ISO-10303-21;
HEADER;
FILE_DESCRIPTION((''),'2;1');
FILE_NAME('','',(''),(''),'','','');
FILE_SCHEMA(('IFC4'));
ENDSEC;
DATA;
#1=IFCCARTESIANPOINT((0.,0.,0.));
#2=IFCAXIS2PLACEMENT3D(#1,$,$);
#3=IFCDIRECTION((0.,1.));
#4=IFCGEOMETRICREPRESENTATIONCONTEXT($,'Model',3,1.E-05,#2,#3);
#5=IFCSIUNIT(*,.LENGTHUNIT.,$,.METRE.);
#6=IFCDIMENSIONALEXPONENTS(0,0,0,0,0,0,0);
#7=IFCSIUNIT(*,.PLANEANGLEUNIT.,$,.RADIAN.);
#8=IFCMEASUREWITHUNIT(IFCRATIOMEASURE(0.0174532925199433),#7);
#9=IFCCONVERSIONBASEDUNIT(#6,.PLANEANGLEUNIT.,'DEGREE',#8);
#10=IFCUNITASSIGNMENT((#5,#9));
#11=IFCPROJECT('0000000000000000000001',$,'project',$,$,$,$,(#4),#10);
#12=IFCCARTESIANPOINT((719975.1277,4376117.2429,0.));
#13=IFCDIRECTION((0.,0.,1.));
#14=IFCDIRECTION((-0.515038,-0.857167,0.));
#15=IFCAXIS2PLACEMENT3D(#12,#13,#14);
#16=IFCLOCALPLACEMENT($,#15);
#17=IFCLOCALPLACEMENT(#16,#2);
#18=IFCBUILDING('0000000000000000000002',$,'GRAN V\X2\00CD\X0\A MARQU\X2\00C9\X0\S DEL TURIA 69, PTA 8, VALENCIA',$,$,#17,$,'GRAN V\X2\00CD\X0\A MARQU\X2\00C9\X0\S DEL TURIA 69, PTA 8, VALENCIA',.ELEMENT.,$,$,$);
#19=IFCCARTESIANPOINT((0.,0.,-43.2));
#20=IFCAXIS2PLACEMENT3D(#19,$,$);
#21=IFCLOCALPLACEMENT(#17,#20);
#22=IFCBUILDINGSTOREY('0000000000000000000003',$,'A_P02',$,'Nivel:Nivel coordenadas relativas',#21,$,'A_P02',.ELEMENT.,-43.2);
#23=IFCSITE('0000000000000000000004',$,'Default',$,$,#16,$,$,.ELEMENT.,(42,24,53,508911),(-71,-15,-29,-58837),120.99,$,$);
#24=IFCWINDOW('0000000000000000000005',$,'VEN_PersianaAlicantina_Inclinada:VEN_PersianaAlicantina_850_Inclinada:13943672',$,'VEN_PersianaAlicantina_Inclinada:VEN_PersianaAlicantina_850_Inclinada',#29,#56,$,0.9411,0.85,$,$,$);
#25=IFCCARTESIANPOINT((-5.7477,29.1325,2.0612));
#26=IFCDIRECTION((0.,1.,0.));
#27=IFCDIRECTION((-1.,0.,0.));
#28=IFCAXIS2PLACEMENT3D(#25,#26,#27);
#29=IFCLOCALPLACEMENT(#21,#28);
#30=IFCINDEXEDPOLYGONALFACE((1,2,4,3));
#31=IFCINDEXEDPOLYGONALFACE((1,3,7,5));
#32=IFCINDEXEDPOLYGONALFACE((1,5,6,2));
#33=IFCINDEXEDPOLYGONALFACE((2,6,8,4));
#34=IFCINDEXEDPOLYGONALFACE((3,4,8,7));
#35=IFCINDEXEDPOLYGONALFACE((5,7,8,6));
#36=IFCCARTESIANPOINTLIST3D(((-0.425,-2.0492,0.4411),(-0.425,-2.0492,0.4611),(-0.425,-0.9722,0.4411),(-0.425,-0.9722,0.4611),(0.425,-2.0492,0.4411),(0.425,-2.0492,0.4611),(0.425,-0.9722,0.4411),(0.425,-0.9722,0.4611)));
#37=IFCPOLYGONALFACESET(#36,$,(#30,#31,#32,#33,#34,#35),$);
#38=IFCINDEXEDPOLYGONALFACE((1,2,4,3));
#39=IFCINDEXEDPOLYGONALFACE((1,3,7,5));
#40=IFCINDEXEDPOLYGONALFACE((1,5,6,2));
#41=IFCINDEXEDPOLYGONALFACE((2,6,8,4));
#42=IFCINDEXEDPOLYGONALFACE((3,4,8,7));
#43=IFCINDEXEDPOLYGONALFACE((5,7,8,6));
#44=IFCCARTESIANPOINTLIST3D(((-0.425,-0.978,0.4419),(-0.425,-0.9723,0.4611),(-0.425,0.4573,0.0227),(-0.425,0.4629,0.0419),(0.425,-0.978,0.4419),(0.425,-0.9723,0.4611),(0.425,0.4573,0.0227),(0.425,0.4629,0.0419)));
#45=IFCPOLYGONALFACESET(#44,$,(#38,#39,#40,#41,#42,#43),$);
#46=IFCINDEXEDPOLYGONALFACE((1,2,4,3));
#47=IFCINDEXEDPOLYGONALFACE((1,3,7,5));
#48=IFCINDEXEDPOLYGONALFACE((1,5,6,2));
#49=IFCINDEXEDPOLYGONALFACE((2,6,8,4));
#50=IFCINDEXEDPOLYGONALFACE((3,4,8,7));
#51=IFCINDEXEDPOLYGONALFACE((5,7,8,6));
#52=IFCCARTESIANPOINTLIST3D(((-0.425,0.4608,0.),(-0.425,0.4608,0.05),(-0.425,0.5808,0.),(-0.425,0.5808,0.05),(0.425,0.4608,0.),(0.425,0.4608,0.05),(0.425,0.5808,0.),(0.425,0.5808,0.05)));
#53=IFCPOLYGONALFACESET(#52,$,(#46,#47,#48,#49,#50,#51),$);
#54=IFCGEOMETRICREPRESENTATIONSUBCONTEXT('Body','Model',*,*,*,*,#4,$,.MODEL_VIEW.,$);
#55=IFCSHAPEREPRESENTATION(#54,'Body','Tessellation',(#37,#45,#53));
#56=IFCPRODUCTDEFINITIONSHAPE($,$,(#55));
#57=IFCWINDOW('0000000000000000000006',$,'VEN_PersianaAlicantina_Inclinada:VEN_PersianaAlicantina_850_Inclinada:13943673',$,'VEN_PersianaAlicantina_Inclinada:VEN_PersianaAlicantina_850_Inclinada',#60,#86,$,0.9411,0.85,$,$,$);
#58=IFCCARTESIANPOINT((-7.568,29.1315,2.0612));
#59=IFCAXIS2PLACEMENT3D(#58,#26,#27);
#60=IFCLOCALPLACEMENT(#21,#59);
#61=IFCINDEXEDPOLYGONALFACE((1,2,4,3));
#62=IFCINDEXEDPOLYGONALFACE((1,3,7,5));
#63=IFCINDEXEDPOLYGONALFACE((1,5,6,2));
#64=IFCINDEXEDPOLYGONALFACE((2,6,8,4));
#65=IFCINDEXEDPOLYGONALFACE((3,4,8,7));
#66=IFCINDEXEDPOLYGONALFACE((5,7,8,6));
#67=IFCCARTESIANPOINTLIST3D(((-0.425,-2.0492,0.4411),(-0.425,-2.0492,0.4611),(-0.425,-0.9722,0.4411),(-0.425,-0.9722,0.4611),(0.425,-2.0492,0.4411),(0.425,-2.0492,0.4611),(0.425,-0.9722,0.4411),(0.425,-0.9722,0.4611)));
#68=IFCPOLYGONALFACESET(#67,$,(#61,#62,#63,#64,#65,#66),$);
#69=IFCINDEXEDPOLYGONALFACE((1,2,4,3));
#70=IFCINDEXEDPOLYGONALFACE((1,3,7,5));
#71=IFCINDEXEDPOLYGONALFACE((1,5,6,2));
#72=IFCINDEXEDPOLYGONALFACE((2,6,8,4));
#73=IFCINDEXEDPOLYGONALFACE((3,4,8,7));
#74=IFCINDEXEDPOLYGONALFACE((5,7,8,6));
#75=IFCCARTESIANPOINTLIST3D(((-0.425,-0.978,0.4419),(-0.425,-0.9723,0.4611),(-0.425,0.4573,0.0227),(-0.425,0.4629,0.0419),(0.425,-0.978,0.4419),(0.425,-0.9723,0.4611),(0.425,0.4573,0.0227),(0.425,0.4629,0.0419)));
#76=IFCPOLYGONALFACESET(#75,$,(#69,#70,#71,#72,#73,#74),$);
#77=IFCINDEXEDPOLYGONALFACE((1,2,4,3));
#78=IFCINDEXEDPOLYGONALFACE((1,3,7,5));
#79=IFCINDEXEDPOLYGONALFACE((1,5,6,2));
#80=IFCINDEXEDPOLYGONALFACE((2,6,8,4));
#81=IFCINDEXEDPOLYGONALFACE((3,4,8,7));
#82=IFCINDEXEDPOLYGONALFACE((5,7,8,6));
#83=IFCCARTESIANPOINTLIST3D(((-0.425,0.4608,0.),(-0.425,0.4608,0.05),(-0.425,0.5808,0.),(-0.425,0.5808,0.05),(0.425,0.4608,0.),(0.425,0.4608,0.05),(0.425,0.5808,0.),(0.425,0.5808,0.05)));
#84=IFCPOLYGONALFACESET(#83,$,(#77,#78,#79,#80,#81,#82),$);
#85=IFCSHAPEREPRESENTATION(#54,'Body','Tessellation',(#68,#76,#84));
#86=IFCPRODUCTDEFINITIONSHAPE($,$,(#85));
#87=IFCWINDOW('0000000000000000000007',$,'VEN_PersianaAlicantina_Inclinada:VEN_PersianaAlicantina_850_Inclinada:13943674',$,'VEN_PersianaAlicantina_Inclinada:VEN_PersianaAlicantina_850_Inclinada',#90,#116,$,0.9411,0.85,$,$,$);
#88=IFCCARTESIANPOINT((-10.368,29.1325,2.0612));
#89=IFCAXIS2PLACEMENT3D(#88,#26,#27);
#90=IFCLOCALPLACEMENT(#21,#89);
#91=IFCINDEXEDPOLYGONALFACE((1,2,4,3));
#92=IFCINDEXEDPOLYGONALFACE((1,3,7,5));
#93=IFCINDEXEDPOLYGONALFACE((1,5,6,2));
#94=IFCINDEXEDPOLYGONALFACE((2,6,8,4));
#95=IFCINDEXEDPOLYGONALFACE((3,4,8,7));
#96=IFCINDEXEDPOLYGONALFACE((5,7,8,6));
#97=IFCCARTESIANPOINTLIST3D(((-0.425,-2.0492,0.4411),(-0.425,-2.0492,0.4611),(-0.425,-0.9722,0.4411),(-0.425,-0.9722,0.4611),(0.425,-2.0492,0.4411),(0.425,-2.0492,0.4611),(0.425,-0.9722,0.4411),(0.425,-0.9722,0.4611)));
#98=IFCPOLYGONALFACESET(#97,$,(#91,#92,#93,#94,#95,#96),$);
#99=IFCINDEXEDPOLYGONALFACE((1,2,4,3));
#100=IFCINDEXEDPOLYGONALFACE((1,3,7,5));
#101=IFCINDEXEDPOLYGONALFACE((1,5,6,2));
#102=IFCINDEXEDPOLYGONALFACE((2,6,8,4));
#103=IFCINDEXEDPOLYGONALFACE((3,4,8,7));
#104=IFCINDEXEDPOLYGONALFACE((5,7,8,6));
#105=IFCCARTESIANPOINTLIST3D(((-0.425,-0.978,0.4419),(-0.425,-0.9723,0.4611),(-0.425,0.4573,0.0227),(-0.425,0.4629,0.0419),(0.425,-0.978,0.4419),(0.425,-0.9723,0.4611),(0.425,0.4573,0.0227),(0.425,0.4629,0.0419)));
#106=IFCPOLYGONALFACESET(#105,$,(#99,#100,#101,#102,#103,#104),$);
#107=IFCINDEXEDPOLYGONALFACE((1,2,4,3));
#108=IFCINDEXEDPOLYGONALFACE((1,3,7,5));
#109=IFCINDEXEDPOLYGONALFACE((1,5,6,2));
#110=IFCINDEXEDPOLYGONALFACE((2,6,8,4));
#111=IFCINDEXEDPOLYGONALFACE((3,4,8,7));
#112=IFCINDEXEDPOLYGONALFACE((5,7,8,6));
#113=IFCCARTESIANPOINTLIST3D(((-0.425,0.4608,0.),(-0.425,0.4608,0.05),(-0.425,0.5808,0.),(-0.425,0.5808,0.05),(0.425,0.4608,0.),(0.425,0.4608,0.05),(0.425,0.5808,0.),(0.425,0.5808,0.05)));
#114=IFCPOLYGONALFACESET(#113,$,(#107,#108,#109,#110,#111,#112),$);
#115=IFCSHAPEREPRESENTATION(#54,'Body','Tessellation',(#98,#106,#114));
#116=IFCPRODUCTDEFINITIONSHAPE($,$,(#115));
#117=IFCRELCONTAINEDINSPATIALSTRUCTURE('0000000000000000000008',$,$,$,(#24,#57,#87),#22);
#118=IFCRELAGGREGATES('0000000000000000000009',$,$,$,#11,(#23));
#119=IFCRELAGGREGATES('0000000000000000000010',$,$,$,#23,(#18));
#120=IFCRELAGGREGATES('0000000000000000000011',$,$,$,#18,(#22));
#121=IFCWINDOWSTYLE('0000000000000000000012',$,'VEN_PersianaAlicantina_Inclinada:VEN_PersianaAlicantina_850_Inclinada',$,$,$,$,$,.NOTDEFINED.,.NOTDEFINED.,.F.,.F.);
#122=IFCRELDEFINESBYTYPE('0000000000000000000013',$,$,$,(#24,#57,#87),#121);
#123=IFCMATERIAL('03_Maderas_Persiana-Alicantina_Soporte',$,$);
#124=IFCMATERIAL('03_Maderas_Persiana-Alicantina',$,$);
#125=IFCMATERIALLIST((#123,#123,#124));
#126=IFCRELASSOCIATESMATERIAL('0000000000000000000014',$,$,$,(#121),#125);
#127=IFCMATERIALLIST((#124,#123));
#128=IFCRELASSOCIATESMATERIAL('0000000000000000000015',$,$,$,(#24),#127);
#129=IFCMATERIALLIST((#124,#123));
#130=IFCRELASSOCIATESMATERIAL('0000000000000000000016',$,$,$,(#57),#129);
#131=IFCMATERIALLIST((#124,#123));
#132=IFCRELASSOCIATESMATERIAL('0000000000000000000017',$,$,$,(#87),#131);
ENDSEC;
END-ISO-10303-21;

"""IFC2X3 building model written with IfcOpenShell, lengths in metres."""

from ifc_helpers import new_model, entity, si_unit, converted_unit, direction, frame, frame_2d, origin, place, context, subcontext, project, spatial, rectangle, extrude, source, transform, mapped, material, material_list, type_object, type_shapes, element, save


model = new_model("IFC2X3")

# Units and contexts
model_context = context("Model", 3, precision=1e-05, world=origin(), true_north=direction((0.0, 1.0)))
body_context = subcontext(model_context, "Body", "Model", "MODEL_VIEW")
ifc_project = project(units=[si_unit("LENGTHUNIT", "METRE"), converted_unit("PLANEANGLEUNIT", "DEGREE", entity("IfcRatioMeasure", 0.0174532925199433), si_unit("PLANEANGLEUNIT", "RADIAN"), dimensions=[0, 0, 0, 0, 0, 0, 0])], contexts=[model_context])

# Site, building, storey
site_placement = place(None, frame((719975.1277, 4376117.2429, 0.0), z_axis=(0.0, 0.0, 1.0), x_axis=(-0.515038, -0.857167, 0.0)))
site = spatial("IfcSite", under=ifc_project, at=site_placement, Name="Default", CompositionType="ELEMENT", RefLatitude=(42, 24, 53, 508911), RefLongitude=(-71, -15, -29, -58837), RefElevation=120.99)
building_placement = place(site_placement, origin())
building = spatial("IfcBuilding", under=site, at=building_placement, Name="GRAN VÍA MARQUÉS DEL TURIA 69, PTA 8, VALENCIA", LongName="GRAN VÍA MARQUÉS DEL TURIA 69, PTA 8, VALENCIA", CompositionType="ELEMENT")
storey_placement = place(building_placement, frame((0.0, 0.0, -43.2)))
storey = spatial("IfcBuildingStorey", under=building, at=storey_placement, Name="A_P02", ObjectType="Nivel:Nivel coordenadas relativas", LongName="A_P02", CompositionType="ELEMENT", Elevation=-43.2)

# Windows
ifc_material_1 = material(Name="03_Maderas_Persiana-Alicantina_Soporte")
ifc_material_2 = material(Name="03_Maderas_Persiana-Alicantina")
ifc_material_list_1 = material_list([ifc_material_2, ifc_material_1])
ifc_material_list_2 = material_list([ifc_material_1, ifc_material_1, ifc_material_2])
window_style_1 = type_object("IfcWindowStyle", Name="VEN_PersianaAlicantina_Inclinada:VEN_PersianaAlicantina_850_Inclinada", ConstructionType="NOTDEFINED", OperationType="NOTDEFINED", ParameterTakesPrecedence=False, Sizeable=False, material=ifc_material_list_2)
shared_shape_1 = source(origin(), body_context, "Body", "SweptSolid", [
    extrude(rectangle(XDim=0.85, YDim=1.077, at=frame_2d((0.0, 0.0), x_axis=(1.0, 0.0))), frame((0.0, -1.5107, 0.4411), z_axis=(0.0, 0.0, 1.0), x_axis=(-1.0, 0.0, 0.0)), (0.0, 0.0, 1.0), 0.02),
    extrude(rectangle(XDim=0.02, YDim=1.4953, at=frame_2d((0.0, 0.0), x_axis=(0.0, 1.0))), frame((-0.425, -0.2575, 0.2419), z_axis=(1.0, 0.0, 0.0), x_axis=(0.0, 0.959885, -0.280394)), (0.0, 0.0, 1.0), 0.85),
    extrude(rectangle(XDim=0.85, YDim=0.12, at=frame_2d((0.0, 0.0), x_axis=(1.0, 0.0))), frame((0.0, 0.5208, 0.0), z_axis=(0.0, 0.0, 1.0), x_axis=(-1.0, 0.0, 0.0)), (0.0, 0.0, 1.0), 0.05),
])
type_shapes(window_style_1, [shared_shape_1])
window_1_placement = place(storey_placement, frame((-5.7477, 29.1325, 2.0612), z_axis=(0.0, 1.0, 0.0), x_axis=(-1.0, 0.0, 0.0)))
element("IfcWindow", 1, at=window_1_placement, inside=storey, type_object=window_style_1, material=ifc_material_list_1, Name="VEN_PersianaAlicantina_Inclinada:VEN_PersianaAlicantina_850_Inclinada:13943672", ObjectType="VEN_PersianaAlicantina_Inclinada:VEN_PersianaAlicantina_850_Inclinada", OverallHeight=0.9411, OverallWidth=0.85, context=body_context, shape_type="MappedRepresentation", body=[
    mapped(shared_shape_1, transform((0.0, 0.0, 0.0), scale=1.0)),
])
ifc_material_list_3 = material_list([ifc_material_2, ifc_material_1])
window_2_placement = place(storey_placement, frame((-7.568, 29.1315, 2.0612), z_axis=(0.0, 1.0, 0.0), x_axis=(-1.0, 0.0, 0.0)))
element("IfcWindow", 2, at=window_2_placement, inside=storey, type_object=window_style_1, material=ifc_material_list_3, Name="VEN_PersianaAlicantina_Inclinada:VEN_PersianaAlicantina_850_Inclinada:13943673", ObjectType="VEN_PersianaAlicantina_Inclinada:VEN_PersianaAlicantina_850_Inclinada", OverallHeight=0.9411, OverallWidth=0.85, context=body_context, shape_type="MappedRepresentation", body=[
    mapped(shared_shape_1, transform((0.0, 0.0, 0.0), scale=1.0)),
])
ifc_material_list_4 = material_list([ifc_material_2, ifc_material_1])
window_3_placement = place(storey_placement, frame((-10.368, 29.1325, 2.0612), z_axis=(0.0, 1.0, 0.0), x_axis=(-1.0, 0.0, 0.0)))
element("IfcWindow", 3, at=window_3_placement, inside=storey, type_object=window_style_1, material=ifc_material_list_4, Name="VEN_PersianaAlicantina_Inclinada:VEN_PersianaAlicantina_850_Inclinada:13943674", ObjectType="VEN_PersianaAlicantina_Inclinada:VEN_PersianaAlicantina_850_Inclinada", OverallHeight=0.9411, OverallWidth=0.85, context=body_context, shape_type="MappedRepresentation", body=[
    mapped(shared_shape_1, transform((0.0, 0.0, 0.0), scale=1.0)),
])

save(model, "model.ifc")
